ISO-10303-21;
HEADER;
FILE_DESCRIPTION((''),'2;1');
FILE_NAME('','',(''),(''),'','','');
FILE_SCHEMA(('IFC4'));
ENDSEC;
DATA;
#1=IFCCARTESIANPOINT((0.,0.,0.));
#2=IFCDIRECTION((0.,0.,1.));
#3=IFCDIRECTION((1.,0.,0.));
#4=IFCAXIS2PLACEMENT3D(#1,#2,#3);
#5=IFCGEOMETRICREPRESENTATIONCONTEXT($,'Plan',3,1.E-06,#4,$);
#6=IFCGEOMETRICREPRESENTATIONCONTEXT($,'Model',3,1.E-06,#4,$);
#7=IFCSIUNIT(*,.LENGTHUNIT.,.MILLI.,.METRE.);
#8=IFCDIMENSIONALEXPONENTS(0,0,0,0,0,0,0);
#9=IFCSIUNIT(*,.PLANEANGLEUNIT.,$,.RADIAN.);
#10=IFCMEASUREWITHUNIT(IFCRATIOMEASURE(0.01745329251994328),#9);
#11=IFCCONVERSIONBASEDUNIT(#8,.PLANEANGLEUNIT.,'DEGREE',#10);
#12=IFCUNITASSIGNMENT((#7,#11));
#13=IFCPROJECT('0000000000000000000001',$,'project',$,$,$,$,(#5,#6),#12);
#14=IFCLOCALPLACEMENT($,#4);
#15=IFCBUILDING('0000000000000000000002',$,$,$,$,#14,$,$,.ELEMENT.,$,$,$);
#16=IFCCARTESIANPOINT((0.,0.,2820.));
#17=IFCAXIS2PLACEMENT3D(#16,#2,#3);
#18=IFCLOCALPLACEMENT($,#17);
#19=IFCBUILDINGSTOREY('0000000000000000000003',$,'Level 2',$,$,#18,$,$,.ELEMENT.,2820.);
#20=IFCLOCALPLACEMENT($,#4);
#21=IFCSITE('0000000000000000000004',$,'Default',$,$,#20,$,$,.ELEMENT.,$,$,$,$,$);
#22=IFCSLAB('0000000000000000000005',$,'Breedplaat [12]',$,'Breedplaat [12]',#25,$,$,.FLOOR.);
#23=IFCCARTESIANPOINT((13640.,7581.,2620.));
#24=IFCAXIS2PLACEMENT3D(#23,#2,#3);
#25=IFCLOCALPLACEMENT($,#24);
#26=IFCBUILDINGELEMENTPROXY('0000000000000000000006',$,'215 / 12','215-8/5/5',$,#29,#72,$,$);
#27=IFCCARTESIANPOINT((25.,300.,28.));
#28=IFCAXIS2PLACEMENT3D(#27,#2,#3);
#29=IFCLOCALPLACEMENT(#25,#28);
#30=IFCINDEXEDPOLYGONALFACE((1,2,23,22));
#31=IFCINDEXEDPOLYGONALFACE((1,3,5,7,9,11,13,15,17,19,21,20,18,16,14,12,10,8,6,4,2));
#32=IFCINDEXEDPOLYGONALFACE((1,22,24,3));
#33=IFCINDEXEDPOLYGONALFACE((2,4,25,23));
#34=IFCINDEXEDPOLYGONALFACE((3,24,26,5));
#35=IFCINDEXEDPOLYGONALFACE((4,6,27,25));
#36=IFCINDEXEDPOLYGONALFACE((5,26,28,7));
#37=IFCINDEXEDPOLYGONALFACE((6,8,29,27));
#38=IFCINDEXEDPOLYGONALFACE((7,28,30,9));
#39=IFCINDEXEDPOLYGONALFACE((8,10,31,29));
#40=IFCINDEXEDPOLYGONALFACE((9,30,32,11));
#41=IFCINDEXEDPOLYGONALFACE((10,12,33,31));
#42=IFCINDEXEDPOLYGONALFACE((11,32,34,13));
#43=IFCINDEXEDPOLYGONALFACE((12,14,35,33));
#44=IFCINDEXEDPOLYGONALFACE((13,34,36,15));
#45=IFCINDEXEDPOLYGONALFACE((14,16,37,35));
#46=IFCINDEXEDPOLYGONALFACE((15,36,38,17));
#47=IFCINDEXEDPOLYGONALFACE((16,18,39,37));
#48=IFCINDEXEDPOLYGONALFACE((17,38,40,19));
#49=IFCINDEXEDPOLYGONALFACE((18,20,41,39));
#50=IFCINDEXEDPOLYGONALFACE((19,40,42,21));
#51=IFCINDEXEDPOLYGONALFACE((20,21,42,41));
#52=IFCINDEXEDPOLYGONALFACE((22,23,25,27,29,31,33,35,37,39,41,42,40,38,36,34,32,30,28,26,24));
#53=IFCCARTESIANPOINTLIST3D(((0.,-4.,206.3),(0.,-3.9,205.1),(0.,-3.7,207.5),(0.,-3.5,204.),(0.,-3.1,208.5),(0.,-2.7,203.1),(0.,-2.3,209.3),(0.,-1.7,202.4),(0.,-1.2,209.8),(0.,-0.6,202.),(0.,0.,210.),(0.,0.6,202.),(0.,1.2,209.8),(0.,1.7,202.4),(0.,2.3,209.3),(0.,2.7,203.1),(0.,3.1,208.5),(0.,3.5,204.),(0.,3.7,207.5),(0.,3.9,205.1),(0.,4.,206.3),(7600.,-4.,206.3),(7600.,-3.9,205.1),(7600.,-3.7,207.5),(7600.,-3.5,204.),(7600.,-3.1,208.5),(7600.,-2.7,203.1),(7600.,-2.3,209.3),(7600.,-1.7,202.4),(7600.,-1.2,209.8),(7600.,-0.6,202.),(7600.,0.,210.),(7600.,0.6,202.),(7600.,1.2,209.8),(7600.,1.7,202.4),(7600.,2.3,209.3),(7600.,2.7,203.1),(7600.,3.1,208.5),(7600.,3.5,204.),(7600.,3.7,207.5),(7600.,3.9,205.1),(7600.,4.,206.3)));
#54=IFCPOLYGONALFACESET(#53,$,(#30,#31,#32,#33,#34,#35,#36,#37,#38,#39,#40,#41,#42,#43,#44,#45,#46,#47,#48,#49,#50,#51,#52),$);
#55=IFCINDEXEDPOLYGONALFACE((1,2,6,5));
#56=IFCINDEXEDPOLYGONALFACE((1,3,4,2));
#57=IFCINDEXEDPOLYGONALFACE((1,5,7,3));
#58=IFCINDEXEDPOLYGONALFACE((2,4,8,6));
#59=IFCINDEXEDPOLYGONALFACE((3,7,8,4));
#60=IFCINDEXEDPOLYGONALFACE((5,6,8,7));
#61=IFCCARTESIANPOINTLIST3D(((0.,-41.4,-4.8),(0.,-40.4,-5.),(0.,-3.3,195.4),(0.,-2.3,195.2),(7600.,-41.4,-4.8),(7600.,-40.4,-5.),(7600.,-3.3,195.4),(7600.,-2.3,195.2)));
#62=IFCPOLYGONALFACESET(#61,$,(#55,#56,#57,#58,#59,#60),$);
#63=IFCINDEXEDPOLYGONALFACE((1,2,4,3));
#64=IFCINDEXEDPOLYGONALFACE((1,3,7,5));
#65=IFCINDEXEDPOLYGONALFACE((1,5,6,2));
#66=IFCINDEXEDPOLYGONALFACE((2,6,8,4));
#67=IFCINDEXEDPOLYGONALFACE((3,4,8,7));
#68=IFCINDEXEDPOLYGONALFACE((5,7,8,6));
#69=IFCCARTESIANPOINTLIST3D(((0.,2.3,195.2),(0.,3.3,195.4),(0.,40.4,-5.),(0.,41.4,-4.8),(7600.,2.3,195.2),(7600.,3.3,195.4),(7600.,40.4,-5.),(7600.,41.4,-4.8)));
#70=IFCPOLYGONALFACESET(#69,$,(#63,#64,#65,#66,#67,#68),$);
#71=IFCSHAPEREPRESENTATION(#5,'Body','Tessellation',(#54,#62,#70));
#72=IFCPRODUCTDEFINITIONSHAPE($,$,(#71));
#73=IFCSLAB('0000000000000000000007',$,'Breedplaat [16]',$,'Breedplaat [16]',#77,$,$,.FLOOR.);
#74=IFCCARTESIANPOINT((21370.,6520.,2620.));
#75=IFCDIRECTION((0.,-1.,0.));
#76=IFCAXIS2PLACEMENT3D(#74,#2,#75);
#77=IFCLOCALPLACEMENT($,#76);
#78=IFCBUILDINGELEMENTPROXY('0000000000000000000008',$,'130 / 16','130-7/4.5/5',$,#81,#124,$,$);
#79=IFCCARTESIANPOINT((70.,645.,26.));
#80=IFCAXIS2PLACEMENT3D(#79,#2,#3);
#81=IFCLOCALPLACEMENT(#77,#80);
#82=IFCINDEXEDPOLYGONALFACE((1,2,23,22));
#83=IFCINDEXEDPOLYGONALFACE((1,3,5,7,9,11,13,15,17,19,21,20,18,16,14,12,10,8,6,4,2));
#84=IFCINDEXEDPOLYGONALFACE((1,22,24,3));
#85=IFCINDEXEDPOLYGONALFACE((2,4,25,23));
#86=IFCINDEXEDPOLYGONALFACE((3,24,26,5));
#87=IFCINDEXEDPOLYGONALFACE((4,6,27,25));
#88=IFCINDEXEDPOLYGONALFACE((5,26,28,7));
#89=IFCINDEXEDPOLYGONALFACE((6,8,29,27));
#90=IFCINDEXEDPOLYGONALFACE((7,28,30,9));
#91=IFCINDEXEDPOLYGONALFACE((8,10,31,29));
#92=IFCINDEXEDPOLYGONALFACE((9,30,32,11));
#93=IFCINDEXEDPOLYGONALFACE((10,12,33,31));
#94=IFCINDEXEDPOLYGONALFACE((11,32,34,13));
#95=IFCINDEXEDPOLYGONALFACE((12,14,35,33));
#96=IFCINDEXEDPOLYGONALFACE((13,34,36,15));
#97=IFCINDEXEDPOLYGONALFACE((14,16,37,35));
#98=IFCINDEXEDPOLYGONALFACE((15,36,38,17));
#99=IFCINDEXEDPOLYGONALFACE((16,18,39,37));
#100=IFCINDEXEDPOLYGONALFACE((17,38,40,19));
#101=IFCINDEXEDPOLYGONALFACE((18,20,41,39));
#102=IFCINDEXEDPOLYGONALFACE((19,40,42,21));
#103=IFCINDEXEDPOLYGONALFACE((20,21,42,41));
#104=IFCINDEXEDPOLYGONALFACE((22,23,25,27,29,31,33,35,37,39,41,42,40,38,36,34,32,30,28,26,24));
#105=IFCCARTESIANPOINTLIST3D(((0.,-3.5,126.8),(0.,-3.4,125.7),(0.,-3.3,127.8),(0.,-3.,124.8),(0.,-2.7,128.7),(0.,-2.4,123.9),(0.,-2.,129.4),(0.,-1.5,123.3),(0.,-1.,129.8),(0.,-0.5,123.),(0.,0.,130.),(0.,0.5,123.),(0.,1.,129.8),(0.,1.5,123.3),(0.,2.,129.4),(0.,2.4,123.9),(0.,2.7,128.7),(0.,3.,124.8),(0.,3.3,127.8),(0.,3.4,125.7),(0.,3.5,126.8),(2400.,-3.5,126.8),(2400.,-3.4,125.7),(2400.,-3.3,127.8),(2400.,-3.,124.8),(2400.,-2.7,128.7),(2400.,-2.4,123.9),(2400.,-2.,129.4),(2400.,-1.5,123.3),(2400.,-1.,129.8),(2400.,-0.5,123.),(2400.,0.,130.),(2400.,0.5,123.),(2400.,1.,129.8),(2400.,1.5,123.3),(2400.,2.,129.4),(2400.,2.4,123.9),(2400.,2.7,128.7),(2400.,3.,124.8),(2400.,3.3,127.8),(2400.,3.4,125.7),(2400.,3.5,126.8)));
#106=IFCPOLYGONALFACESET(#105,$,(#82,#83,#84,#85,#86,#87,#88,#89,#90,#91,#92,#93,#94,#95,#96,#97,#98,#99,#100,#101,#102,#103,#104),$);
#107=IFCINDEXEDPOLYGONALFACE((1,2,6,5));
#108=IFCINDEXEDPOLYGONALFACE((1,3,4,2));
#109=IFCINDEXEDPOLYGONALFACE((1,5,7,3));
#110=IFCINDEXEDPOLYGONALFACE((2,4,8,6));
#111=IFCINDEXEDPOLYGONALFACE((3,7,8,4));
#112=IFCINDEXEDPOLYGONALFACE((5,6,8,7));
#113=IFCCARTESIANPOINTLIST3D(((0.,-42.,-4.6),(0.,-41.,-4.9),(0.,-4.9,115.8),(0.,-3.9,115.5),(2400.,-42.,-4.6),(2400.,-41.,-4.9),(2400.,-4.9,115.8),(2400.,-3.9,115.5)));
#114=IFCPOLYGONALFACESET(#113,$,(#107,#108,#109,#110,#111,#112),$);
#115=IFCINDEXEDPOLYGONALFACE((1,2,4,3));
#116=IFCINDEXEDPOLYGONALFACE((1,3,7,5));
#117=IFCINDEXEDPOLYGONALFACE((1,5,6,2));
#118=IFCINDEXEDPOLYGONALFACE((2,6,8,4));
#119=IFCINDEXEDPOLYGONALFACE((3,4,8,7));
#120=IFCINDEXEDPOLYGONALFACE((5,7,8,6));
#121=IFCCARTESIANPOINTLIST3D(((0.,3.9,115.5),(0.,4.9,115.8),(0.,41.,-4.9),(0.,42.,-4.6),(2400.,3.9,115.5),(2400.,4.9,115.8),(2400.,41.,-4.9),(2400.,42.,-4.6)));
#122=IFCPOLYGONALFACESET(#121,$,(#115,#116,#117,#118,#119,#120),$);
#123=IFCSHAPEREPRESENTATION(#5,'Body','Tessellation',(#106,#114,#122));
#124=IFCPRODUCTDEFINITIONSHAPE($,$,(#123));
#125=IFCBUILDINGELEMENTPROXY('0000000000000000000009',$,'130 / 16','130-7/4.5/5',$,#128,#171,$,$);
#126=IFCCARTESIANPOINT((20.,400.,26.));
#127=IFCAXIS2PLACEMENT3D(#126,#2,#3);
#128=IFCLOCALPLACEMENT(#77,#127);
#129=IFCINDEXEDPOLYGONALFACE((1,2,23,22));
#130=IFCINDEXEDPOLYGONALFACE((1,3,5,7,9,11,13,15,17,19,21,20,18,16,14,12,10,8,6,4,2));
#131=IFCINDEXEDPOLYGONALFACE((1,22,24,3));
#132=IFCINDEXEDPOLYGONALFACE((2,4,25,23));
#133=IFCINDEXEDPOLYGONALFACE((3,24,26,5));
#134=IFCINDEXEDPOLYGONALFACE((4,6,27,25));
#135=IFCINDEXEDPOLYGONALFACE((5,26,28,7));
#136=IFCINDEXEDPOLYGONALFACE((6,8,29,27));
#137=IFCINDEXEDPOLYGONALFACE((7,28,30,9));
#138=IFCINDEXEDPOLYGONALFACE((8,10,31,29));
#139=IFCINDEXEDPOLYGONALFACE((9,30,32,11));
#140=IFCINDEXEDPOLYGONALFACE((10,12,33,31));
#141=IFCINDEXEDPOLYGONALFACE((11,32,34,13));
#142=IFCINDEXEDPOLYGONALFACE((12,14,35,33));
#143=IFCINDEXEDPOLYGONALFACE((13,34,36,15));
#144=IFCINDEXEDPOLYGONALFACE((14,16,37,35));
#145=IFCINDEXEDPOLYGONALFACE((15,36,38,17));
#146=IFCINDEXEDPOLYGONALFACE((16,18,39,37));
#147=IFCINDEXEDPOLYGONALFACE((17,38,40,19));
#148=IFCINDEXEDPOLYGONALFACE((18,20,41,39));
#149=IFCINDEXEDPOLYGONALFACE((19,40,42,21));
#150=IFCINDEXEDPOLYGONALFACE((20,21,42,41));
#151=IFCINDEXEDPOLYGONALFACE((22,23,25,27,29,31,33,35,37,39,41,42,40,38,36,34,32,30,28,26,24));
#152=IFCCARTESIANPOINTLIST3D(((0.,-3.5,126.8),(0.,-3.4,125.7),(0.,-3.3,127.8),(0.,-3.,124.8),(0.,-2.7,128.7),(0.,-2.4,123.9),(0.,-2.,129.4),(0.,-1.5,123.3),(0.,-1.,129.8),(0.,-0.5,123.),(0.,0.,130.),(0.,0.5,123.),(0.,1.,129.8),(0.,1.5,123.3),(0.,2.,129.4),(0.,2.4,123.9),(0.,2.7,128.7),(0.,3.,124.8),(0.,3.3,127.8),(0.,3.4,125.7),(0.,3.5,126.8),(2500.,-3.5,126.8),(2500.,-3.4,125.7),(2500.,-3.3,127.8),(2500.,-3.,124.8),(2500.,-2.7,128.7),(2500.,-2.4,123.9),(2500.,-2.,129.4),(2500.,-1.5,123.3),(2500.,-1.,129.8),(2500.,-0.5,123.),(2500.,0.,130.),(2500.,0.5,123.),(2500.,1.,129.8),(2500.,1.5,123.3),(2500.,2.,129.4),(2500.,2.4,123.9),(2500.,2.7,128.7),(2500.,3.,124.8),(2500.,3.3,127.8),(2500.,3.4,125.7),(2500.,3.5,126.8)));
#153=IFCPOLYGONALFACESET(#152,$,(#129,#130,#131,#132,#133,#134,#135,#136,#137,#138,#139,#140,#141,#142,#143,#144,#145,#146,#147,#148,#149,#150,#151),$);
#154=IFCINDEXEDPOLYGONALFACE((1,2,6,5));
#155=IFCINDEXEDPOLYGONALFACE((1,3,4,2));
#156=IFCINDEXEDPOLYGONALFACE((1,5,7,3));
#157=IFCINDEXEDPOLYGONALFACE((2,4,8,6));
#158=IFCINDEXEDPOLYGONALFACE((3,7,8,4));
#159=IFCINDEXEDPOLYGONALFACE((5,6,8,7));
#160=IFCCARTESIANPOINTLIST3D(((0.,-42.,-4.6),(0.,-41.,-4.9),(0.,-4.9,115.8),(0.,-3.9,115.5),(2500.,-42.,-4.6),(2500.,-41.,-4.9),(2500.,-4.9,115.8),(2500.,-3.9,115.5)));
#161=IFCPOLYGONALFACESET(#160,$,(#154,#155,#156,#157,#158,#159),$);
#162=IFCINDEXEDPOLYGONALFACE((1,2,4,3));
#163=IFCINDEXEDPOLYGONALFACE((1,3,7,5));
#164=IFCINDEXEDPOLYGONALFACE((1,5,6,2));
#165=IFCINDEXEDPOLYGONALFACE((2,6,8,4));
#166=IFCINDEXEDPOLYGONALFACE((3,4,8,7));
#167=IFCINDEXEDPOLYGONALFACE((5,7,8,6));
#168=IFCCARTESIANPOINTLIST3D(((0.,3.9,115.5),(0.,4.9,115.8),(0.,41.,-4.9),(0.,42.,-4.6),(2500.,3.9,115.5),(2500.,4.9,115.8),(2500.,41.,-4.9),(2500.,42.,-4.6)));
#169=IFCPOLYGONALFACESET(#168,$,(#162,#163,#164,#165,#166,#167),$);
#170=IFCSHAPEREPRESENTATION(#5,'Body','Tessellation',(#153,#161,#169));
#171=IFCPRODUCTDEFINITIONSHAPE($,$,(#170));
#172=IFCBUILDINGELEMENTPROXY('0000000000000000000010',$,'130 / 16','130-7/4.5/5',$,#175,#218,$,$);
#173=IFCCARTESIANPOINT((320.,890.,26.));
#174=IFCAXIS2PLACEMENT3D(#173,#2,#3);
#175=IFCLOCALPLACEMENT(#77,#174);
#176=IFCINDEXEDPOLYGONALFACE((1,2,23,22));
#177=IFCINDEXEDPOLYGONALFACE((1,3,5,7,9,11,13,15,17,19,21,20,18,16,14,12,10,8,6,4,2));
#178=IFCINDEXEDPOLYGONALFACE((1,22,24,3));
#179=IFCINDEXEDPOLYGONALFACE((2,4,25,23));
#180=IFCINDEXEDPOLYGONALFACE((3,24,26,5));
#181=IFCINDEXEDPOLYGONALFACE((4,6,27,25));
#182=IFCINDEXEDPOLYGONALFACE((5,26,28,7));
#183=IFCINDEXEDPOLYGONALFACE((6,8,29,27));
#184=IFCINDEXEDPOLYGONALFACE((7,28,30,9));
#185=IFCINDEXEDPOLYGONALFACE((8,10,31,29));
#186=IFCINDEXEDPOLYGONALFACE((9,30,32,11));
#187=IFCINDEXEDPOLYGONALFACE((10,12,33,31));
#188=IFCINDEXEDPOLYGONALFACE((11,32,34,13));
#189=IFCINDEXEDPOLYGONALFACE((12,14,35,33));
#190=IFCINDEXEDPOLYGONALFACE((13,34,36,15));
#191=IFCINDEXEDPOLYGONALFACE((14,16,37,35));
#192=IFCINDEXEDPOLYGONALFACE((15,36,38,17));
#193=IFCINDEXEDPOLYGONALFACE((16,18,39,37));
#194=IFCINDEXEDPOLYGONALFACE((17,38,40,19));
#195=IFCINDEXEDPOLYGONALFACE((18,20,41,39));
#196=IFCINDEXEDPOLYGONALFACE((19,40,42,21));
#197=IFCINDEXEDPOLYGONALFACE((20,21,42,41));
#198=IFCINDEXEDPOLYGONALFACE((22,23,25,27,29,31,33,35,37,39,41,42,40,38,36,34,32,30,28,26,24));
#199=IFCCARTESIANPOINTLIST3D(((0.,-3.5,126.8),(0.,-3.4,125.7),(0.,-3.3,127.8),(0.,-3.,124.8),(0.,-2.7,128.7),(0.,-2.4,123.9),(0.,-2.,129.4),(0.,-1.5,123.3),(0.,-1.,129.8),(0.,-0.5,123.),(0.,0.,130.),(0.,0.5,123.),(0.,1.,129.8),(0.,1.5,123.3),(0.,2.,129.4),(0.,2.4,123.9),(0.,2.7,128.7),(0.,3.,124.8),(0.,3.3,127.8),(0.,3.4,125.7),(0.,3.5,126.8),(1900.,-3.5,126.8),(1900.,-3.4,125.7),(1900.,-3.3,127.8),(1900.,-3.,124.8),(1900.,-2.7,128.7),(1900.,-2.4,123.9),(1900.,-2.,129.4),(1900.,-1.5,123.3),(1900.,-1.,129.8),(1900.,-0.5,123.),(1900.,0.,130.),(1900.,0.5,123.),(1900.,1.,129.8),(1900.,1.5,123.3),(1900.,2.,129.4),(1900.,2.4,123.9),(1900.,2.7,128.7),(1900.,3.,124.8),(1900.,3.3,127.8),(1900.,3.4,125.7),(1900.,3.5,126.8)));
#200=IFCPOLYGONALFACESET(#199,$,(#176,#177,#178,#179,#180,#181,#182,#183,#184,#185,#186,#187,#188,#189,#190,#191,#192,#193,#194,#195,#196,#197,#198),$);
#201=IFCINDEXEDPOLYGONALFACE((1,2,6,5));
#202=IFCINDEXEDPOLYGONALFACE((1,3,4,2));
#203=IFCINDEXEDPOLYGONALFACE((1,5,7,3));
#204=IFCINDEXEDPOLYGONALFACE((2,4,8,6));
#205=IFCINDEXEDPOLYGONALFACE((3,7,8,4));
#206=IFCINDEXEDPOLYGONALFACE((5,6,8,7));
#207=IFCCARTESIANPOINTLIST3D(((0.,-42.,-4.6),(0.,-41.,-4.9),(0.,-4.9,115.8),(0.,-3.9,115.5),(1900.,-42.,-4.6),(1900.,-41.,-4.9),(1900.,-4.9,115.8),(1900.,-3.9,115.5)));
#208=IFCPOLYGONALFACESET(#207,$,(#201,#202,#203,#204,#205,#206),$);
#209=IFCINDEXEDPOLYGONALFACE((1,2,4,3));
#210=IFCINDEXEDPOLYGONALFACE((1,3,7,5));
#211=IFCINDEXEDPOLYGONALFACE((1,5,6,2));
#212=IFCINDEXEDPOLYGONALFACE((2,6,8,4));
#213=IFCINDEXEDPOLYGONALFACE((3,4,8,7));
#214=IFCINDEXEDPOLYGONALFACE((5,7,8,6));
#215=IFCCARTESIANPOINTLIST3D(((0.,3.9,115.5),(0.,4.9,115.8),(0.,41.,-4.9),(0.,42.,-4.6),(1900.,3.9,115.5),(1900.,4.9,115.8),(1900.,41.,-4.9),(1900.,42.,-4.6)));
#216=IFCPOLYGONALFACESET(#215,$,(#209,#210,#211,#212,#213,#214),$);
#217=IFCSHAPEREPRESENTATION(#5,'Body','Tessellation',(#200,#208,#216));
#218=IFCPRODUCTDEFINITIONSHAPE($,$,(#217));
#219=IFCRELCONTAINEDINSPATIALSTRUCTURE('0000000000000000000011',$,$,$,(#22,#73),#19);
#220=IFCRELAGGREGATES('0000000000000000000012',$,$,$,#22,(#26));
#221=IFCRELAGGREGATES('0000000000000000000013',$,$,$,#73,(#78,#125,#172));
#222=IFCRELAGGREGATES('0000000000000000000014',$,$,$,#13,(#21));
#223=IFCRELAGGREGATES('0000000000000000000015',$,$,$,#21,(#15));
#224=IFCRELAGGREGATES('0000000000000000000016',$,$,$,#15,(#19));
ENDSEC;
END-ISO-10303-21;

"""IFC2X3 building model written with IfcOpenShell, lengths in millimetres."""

from ifc_helpers import new_model, entity, si_unit, converted_unit, frame, origin_with_axes, origin_2d_with_axis, place, context, project, spatial, rectangle, circle, extrude, element, aggregate, save


model = new_model("IFC2X3")

# Units and contexts
plan_context = context("Plan", 3, precision=1e-06, world=origin_with_axes())
model_context = context("Model", 3, precision=1e-06, world=origin_with_axes())
ifc_project = project(units=[si_unit("LENGTHUNIT", "METRE", prefix="MILLI"), converted_unit("PLANEANGLEUNIT", "DEGREE", entity("IfcRatioMeasure", 0.01745329251994328), si_unit("PLANEANGLEUNIT", "RADIAN"), dimensions=[0, 0, 0, 0, 0, 0, 0])], contexts=[plan_context, model_context])

# Site, building, storey
site_placement = place(None, origin_with_axes())
site = spatial("IfcSite", under=ifc_project, at=site_placement, Name="Default", CompositionType="ELEMENT")
building_placement = place(None, origin_with_axes())
building = spatial("IfcBuilding", under=site, at=building_placement, CompositionType="ELEMENT")
storey_placement = place(None, frame((0.0, 0.0, 2820.0), z_axis=(0.0, 0.0, 1.0), x_axis=(1.0, 0.0, 0.0)))
storey = spatial("IfcBuildingStorey", under=building, at=storey_placement, Name="Level 2", CompositionType="ELEMENT", Elevation=2820.0)

# Slab, building element proxy
slab_1_placement = place(None, frame((13640.0, 7581.0, 2620.0), z_axis=(0.0, 0.0, 1.0), x_axis=(1.0, 0.0, 0.0)))
slab_1 = element("IfcSlab", 1, at=slab_1_placement, inside=storey, Name="Breedplaat [12]", ObjectType="Breedplaat [12]", PredefinedType="FLOOR")
proxy_1_placement = place(slab_1_placement, frame((25.0, 300.0, 28.0), z_axis=(0.0, 0.0, 1.0), x_axis=(1.0, 0.0, 0.0)))
proxy_1 = element("IfcBuildingElementProxy", 2, at=proxy_1_placement, Name="215 / 12", Description="215-8/5/5", context=plan_context, shape_type="SweptSolid", body=[
    extrude(circle(Radius=4.0, at=origin_2d_with_axis()), frame((0.0, 0.0, 206.0), z_axis=(1.0, 0.0, 0.0), x_axis=(0.0, 0.0, 1.0)), (0.0, 0.0, 1.0), 7600.0),
    extrude(rectangle(XDim=203.8, YDim=1.0, at=origin_2d_with_axis()), frame((0.0, -21.9, 95.2), z_axis=(1.0, 0.0, 0.0), x_axis=(0.0, 0.187112, 0.982339)), (0.0, 0.0, 1.0), 7600.0),
    extrude(rectangle(XDim=203.8, YDim=1.0, at=origin_2d_with_axis()), frame((0.0, 21.9, 95.2), z_axis=(1.0, 0.0, 0.0), x_axis=(0.0, -0.187112, 0.982339)), (0.0, 0.0, 1.0), 7600.0),
])
aggregate(slab_1, [proxy_1])

# Slab, building element proxies
slab_2_placement = place(None, frame((21370.0, 6520.0, 2620.0), z_axis=(0.0, 0.0, 1.0), x_axis=(0.0, -1.0, 0.0)))
slab_2 = element("IfcSlab", 3, at=slab_2_placement, inside=storey, Name="Breedplaat [16]", ObjectType="Breedplaat [16]", PredefinedType="FLOOR")
proxy_2_placement = place(slab_2_placement, frame((70.0, 645.0, 26.0), z_axis=(0.0, 0.0, 1.0), x_axis=(1.0, 0.0, 0.0)))
proxy_2 = element("IfcBuildingElementProxy", 4, at=proxy_2_placement, Name="130 / 16", Description="130-7/4.5/5", context=plan_context, shape_type="SweptSolid", body=[
    extrude(circle(Radius=3.5, at=origin_2d_with_axis()), frame((0.0, 0.0, 126.5), z_axis=(1.0, 0.0, 0.0), x_axis=(0.0, 0.0, 1.0)), (0.0, 0.0, 1.0), 2400.0),
    extrude(rectangle(XDim=126.0, YDim=1.0, at=origin_2d_with_axis()), frame((0.0, -22.9, 55.4), z_axis=(1.0, 0.0, 0.0), x_axis=(0.0, 0.294086, 0.955779)), (0.0, 0.0, 1.0), 2400.0),
    extrude(rectangle(XDim=126.0, YDim=1.0, at=origin_2d_with_axis()), frame((0.0, 22.9, 55.4), z_axis=(1.0, 0.0, 0.0), x_axis=(0.0, -0.294086, 0.955779)), (0.0, 0.0, 1.0), 2400.0),
])
proxy_3_placement = place(slab_2_placement, frame((20.0, 400.0, 26.0), z_axis=(0.0, 0.0, 1.0), x_axis=(1.0, 0.0, 0.0)))
proxy_3 = element("IfcBuildingElementProxy", 5, at=proxy_3_placement, Name="130 / 16", Description="130-7/4.5/5", context=plan_context, shape_type="SweptSolid", body=[
    extrude(circle(Radius=3.5, at=origin_2d_with_axis()), frame((0.0, 0.0, 126.5), z_axis=(1.0, 0.0, 0.0), x_axis=(0.0, 0.0, 1.0)), (0.0, 0.0, 1.0), 2500.0),
    extrude(rectangle(XDim=126.0, YDim=1.0, at=origin_2d_with_axis()), frame((0.0, -22.9, 55.4), z_axis=(1.0, 0.0, 0.0), x_axis=(0.0, 0.294086, 0.955779)), (0.0, 0.0, 1.0), 2500.0),
    extrude(rectangle(XDim=126.0, YDim=1.0, at=origin_2d_with_axis()), frame((0.0, 22.9, 55.4), z_axis=(1.0, 0.0, 0.0), x_axis=(0.0, -0.294086, 0.955779)), (0.0, 0.0, 1.0), 2500.0),
])
proxy_4_placement = place(slab_2_placement, frame((320.0, 890.0, 26.0), z_axis=(0.0, 0.0, 1.0), x_axis=(1.0, 0.0, 0.0)))
proxy_4 = element("IfcBuildingElementProxy", 6, at=proxy_4_placement, Name="130 / 16", Description="130-7/4.5/5", context=plan_context, shape_type="SweptSolid", body=[
    extrude(circle(Radius=3.5, at=origin_2d_with_axis()), frame((0.0, 0.0, 126.5), z_axis=(1.0, 0.0, 0.0), x_axis=(0.0, 0.0, 1.0)), (0.0, 0.0, 1.0), 1900.0),
    extrude(rectangle(XDim=126.0, YDim=1.0, at=origin_2d_with_axis()), frame((0.0, -22.9, 55.4), z_axis=(1.0, 0.0, 0.0), x_axis=(0.0, 0.294086, 0.955779)), (0.0, 0.0, 1.0), 1900.0),
    extrude(rectangle(XDim=126.0, YDim=1.0, at=origin_2d_with_axis()), frame((0.0, 22.9, 55.4), z_axis=(1.0, 0.0, 0.0), x_axis=(0.0, -0.294086, 0.955779)), (0.0, 0.0, 1.0), 1900.0),
])
aggregate(slab_2, [proxy_2, proxy_3, proxy_4])

save(model, "model.ifc")
